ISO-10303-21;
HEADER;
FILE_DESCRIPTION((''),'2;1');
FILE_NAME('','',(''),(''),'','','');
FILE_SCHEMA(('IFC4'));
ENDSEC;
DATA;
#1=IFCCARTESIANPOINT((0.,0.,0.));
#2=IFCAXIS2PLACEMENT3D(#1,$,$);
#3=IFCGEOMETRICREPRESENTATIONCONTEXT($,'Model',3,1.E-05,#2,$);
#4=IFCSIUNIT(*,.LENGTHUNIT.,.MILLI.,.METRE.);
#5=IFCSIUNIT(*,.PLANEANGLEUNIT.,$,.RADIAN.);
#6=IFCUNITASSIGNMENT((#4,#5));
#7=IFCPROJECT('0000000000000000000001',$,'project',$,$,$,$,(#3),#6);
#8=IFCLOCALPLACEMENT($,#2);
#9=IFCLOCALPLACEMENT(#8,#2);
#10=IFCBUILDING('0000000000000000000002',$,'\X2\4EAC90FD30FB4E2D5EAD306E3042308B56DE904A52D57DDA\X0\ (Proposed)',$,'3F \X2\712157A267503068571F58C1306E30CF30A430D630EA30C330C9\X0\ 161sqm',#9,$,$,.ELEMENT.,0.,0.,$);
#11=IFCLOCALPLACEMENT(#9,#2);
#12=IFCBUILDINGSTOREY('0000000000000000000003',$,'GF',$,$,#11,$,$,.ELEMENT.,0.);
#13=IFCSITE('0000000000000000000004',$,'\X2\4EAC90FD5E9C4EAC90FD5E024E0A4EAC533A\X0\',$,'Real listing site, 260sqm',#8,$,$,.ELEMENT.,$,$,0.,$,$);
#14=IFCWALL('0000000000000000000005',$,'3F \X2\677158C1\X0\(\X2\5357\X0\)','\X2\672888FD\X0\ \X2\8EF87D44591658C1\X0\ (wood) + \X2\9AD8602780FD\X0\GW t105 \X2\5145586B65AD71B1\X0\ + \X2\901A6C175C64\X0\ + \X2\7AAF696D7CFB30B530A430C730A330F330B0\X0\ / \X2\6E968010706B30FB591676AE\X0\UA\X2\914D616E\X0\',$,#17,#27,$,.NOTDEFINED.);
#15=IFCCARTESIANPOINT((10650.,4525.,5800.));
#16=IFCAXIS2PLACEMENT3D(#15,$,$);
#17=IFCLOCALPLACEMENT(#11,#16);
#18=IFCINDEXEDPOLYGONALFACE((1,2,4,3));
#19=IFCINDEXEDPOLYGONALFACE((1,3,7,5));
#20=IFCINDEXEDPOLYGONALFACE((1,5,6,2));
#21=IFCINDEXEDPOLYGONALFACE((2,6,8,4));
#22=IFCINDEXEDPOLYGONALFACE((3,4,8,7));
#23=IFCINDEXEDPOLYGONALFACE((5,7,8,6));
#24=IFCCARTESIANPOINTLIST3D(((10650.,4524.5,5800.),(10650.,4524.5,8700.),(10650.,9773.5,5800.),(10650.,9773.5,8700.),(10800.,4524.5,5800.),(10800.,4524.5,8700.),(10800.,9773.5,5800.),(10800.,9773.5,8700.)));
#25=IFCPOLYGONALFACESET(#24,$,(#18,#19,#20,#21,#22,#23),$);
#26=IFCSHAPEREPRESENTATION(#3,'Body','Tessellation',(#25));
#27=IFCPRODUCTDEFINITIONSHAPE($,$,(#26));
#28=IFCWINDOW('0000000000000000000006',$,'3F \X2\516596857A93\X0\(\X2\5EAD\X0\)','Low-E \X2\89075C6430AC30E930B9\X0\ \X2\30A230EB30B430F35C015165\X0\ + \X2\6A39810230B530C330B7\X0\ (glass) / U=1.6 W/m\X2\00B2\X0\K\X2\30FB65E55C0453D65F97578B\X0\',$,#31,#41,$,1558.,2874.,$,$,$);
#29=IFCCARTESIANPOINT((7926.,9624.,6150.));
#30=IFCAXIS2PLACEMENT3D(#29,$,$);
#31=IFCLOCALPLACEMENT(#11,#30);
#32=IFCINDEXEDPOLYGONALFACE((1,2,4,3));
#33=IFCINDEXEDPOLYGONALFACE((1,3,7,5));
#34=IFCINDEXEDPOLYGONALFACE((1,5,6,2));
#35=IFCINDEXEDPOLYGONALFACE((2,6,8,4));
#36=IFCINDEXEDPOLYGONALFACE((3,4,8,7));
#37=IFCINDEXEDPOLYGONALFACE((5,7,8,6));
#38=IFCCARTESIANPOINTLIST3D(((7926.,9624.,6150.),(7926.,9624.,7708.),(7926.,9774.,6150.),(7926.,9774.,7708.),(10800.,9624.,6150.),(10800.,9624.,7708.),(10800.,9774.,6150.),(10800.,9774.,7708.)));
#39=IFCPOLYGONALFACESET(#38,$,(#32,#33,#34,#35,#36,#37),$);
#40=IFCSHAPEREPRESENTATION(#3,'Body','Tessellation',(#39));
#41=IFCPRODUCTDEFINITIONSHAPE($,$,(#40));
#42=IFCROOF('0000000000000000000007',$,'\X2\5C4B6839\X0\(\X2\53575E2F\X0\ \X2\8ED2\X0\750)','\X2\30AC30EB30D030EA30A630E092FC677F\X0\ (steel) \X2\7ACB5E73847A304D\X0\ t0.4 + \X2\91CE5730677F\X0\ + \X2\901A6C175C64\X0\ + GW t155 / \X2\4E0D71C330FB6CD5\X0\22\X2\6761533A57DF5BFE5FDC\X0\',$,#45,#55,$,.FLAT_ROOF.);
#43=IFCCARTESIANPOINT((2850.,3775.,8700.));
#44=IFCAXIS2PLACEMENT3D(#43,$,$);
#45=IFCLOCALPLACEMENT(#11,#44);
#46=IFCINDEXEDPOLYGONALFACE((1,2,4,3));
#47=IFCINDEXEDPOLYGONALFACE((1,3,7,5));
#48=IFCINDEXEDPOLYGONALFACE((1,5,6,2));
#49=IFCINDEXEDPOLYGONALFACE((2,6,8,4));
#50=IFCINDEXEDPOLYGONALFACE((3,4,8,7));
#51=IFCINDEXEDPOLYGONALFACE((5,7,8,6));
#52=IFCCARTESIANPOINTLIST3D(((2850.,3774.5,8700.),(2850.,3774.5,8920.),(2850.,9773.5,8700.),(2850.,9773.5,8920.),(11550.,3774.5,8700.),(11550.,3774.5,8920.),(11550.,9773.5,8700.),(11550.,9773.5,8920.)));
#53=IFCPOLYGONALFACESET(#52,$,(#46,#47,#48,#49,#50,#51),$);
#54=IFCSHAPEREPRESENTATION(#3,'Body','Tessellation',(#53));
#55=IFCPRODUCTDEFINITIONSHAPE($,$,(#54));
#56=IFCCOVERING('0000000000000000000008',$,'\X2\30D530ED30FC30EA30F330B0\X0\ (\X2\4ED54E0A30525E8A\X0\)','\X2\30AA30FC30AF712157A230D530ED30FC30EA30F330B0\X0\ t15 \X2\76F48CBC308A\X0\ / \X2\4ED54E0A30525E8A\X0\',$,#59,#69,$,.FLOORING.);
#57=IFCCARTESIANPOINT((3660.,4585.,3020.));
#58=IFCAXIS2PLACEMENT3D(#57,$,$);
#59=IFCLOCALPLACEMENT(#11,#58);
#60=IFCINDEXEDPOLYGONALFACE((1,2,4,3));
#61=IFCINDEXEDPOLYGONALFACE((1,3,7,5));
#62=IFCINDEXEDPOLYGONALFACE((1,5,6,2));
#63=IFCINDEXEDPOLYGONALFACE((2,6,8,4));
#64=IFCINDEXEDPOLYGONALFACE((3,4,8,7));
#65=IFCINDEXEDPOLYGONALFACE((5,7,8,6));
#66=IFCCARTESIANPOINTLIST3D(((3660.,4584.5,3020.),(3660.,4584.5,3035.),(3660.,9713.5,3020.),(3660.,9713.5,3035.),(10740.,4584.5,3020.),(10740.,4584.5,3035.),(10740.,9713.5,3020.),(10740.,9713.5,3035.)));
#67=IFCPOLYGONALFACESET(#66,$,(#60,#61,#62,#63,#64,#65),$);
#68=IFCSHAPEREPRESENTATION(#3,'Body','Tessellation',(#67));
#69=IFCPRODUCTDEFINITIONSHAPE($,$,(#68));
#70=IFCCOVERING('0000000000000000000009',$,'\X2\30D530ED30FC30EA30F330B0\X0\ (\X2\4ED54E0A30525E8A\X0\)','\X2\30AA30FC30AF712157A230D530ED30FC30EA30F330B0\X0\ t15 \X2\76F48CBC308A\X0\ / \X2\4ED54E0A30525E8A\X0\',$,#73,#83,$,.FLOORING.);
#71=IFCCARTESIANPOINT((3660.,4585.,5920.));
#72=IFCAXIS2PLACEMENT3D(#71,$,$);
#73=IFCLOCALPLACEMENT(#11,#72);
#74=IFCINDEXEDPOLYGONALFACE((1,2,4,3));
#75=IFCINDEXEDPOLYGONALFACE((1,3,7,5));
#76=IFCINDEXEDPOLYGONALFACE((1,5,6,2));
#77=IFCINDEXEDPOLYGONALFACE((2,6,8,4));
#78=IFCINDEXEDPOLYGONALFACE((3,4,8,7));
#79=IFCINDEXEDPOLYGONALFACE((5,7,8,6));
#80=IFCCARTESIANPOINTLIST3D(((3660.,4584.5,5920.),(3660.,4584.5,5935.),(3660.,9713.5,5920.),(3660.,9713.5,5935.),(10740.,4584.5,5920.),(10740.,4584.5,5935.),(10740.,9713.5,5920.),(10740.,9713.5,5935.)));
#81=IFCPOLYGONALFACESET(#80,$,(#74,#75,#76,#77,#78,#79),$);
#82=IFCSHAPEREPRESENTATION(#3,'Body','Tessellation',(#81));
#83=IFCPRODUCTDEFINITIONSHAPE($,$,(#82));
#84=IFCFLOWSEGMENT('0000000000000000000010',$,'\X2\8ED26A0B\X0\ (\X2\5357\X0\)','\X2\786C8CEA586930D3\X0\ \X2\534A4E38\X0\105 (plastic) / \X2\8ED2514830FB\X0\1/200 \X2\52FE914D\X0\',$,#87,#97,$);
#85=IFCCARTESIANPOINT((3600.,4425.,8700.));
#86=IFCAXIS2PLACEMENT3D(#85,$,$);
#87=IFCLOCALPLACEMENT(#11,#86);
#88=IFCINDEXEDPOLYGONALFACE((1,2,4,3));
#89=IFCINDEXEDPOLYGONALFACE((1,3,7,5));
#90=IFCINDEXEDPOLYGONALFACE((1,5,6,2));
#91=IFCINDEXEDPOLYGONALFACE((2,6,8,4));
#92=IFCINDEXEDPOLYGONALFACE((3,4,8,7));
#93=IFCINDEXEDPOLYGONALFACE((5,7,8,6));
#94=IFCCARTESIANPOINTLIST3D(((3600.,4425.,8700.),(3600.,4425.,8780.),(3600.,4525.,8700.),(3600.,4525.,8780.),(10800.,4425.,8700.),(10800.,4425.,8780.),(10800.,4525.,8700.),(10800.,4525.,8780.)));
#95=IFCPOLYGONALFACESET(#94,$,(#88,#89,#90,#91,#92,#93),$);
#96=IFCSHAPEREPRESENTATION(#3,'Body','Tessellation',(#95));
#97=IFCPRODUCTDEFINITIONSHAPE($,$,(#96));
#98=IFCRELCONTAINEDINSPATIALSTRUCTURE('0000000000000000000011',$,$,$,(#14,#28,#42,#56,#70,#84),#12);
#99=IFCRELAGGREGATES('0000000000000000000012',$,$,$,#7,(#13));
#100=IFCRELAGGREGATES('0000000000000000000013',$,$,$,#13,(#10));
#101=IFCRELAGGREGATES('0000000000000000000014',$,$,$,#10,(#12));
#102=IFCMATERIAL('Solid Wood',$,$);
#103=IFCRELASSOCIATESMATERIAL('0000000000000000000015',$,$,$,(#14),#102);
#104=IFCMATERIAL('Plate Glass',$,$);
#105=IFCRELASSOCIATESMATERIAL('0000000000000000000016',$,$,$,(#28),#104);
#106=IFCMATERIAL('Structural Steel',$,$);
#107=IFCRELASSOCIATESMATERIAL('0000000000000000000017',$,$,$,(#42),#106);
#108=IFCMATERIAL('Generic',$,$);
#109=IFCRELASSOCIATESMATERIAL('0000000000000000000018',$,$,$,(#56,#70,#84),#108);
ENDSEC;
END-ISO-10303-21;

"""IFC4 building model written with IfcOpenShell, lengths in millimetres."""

from ifc_helpers import new_model, si_unit, frame, frame_2d, origin, place, context, project, spatial, rectangle, extrude, material, element, fill, save


model = new_model("IFC4")

# Units and contexts
model_context = context("Model", 3, precision=1e-05, world=origin())
ifc_project = project(units=[si_unit("LENGTHUNIT", "METRE", prefix="MILLI"), si_unit("PLANEANGLEUNIT", "RADIAN")], contexts=[model_context])

# Site, building, storey
site_placement = place(None, origin())
site = spatial("IfcSite", under=ifc_project, at=site_placement, Name="京都府京都市上京区", ObjectType="Real listing site, 260sqm", CompositionType="ELEMENT", RefElevation=0.0)
building_placement = place(site_placement, origin())
building = spatial("IfcBuilding", under=site, at=building_placement, Name="京都・中庭のある回遊動線 (Proposed)", ObjectType="3F 無垢材と土壁のハイブリッド 161sqm", CompositionType="ELEMENT", ElevationOfRefHeight=0.0, ElevationOfTerrain=0.0)
storey_placement = place(building_placement, origin())
storey = spatial("IfcBuildingStorey", under=building, at=storey_placement, Name="GF", CompositionType="ELEMENT", Elevation=0.0)

# Shared definitions
ifc_material_1 = material(Name="Solid Wood")

# Wall, opening, window
ifc_material_2 = material(Name="Plate Glass")
wall_1_placement = place(storey_placement, frame((10650.0, 4525.0, 5800.0)))
wall_1 = element("IfcWall", 1, at=wall_1_placement, inside=storey, material=ifc_material_1, Name="3F 東壁(南)", Description="木製 軸組外壁 (wood) + 高性能GW t105 充填断熱 + 通気層 + 窯業系サイディング / 準耐火・外皮UA配慮", PredefinedType="NOTDEFINED", context=model_context, shape_type="SweptSolid", body=[
    extrude(rectangle(XDim=150.0, YDim=5249.0, at=frame_2d((75.0, 2624.0))), frame((10650.0, 4525.0, 5800.0)), (0.0, 0.0, 1.0), 2900.0),
])
opening_1_placement = place(storey_placement, frame((7926.0, 9624.0, 6150.0)))
opening_1 = element("IfcOpeningElement", 2, at=opening_1_placement, cuts=wall_1, PredefinedType="NOTDEFINED", context=model_context, shape_type="SweptSolid", body=[
    extrude(rectangle(XDim=2874.0, YDim=150.0, at=frame_2d((1437.0, 75.0))), frame((7926.0, 9624.0, 6150.0)), (0.0, 0.0, 1.0), 1558.0),
])
window_1_placement = place(storey_placement, frame((7926.0, 9624.0, 6150.0)))
window_1 = element("IfcWindow", 3, at=window_1_placement, inside=storey, material=ifc_material_2, Name="3F 入隅窓(庭)", Description="Low-E 複層ガラス アルゴン封入 + 樹脂サッシ (glass) / U=1.6 W/m²K・日射取得型", OverallHeight=1558.0, OverallWidth=2874.0, context=model_context, shape_type="SweptSolid", body=[
    extrude(rectangle(XDim=2874.0, YDim=150.0, at=frame_2d((1437.0, 75.0))), frame((7926.0, 9624.0, 6150.0)), (0.0, 0.0, 1.0), 1558.0),
])
fill(opening_1, window_1)

# Roof
ifc_material_3 = material(Name="Structural Steel")
for number, where, name in (
    (4, (2850.0, 3775.0, 8700.0), "屋根(南帯 軒750)"),
):
    element("IfcRoof", number, at=place(storey_placement, frame(where)), inside=storey, material=ifc_material_3, Name=name, Description="ガルバリウム鋼板 (steel) 立平葺き t0.4 + 野地板 + 通気層 + GW t155 / 不燃・法22条区域対応", PredefinedType="FLAT_ROOF", context=model_context, shape_type="SweptSolid", body=[
        extrude(rectangle(XDim=8700.0, YDim=5999.0, at=frame_2d((4350.0, 2999.0))), frame((2850.0, 3775.0, 8700.0)), (0.0, 0.0, 1.0), 220.0),
    ])

# Coverings
ifc_material_4 = material(Name="Generic")
covering_1_placement = place(storey_placement, frame((3660.0, 4585.0, 3020.0)))
element("IfcCovering", 5, at=covering_1_placement, inside=storey, material=ifc_material_4, Name="フローリング (仕上げ床)", Description="オーク無垢フローリング t15 直貼り / 仕上げ床", PredefinedType="FLOORING", context=model_context, shape_type="SweptSolid", body=[
    extrude(rectangle(XDim=7080.0, YDim=5129.0, at=frame_2d((3540.0, 2564.0))), frame((3660.0, 4585.0, 3020.0)), (0.0, 0.0, 1.0), 15.0),
])
covering_2_placement = place(storey_placement, frame((3660.0, 4585.0, 5920.0)))
element("IfcCovering", 6, at=covering_2_placement, inside=storey, material=ifc_material_4, Name="フローリング (仕上げ床)", Description="オーク無垢フローリング t15 直貼り / 仕上げ床", PredefinedType="FLOORING", context=model_context, shape_type="SweptSolid", body=[
    extrude(rectangle(XDim=7080.0, YDim=5129.0, at=frame_2d((3540.0, 2564.0))), frame((3660.0, 4585.0, 5920.0)), (0.0, 0.0, 1.0), 15.0),
])

# Flow segment
flow_segment_placement = place(storey_placement, frame((3600.0, 4425.0, 8700.0)))
element("IfcFlowSegment", 7, at=flow_segment_placement, inside=storey, material=ifc_material_4, Name="軒樋 (南)", Description="硬質塩ビ 半丸105 (plastic) / 軒先・1/200 勾配", context=model_context, shape_type="SweptSolid", body=[
    extrude(rectangle(XDim=7200.0, YDim=100.0, at=frame_2d((3600.0, 50.0))), frame((3600.0, 4425.0, 8700.0)), (0.0, 0.0, 1.0), 80.0),
])

save(model, "model.ifc")
